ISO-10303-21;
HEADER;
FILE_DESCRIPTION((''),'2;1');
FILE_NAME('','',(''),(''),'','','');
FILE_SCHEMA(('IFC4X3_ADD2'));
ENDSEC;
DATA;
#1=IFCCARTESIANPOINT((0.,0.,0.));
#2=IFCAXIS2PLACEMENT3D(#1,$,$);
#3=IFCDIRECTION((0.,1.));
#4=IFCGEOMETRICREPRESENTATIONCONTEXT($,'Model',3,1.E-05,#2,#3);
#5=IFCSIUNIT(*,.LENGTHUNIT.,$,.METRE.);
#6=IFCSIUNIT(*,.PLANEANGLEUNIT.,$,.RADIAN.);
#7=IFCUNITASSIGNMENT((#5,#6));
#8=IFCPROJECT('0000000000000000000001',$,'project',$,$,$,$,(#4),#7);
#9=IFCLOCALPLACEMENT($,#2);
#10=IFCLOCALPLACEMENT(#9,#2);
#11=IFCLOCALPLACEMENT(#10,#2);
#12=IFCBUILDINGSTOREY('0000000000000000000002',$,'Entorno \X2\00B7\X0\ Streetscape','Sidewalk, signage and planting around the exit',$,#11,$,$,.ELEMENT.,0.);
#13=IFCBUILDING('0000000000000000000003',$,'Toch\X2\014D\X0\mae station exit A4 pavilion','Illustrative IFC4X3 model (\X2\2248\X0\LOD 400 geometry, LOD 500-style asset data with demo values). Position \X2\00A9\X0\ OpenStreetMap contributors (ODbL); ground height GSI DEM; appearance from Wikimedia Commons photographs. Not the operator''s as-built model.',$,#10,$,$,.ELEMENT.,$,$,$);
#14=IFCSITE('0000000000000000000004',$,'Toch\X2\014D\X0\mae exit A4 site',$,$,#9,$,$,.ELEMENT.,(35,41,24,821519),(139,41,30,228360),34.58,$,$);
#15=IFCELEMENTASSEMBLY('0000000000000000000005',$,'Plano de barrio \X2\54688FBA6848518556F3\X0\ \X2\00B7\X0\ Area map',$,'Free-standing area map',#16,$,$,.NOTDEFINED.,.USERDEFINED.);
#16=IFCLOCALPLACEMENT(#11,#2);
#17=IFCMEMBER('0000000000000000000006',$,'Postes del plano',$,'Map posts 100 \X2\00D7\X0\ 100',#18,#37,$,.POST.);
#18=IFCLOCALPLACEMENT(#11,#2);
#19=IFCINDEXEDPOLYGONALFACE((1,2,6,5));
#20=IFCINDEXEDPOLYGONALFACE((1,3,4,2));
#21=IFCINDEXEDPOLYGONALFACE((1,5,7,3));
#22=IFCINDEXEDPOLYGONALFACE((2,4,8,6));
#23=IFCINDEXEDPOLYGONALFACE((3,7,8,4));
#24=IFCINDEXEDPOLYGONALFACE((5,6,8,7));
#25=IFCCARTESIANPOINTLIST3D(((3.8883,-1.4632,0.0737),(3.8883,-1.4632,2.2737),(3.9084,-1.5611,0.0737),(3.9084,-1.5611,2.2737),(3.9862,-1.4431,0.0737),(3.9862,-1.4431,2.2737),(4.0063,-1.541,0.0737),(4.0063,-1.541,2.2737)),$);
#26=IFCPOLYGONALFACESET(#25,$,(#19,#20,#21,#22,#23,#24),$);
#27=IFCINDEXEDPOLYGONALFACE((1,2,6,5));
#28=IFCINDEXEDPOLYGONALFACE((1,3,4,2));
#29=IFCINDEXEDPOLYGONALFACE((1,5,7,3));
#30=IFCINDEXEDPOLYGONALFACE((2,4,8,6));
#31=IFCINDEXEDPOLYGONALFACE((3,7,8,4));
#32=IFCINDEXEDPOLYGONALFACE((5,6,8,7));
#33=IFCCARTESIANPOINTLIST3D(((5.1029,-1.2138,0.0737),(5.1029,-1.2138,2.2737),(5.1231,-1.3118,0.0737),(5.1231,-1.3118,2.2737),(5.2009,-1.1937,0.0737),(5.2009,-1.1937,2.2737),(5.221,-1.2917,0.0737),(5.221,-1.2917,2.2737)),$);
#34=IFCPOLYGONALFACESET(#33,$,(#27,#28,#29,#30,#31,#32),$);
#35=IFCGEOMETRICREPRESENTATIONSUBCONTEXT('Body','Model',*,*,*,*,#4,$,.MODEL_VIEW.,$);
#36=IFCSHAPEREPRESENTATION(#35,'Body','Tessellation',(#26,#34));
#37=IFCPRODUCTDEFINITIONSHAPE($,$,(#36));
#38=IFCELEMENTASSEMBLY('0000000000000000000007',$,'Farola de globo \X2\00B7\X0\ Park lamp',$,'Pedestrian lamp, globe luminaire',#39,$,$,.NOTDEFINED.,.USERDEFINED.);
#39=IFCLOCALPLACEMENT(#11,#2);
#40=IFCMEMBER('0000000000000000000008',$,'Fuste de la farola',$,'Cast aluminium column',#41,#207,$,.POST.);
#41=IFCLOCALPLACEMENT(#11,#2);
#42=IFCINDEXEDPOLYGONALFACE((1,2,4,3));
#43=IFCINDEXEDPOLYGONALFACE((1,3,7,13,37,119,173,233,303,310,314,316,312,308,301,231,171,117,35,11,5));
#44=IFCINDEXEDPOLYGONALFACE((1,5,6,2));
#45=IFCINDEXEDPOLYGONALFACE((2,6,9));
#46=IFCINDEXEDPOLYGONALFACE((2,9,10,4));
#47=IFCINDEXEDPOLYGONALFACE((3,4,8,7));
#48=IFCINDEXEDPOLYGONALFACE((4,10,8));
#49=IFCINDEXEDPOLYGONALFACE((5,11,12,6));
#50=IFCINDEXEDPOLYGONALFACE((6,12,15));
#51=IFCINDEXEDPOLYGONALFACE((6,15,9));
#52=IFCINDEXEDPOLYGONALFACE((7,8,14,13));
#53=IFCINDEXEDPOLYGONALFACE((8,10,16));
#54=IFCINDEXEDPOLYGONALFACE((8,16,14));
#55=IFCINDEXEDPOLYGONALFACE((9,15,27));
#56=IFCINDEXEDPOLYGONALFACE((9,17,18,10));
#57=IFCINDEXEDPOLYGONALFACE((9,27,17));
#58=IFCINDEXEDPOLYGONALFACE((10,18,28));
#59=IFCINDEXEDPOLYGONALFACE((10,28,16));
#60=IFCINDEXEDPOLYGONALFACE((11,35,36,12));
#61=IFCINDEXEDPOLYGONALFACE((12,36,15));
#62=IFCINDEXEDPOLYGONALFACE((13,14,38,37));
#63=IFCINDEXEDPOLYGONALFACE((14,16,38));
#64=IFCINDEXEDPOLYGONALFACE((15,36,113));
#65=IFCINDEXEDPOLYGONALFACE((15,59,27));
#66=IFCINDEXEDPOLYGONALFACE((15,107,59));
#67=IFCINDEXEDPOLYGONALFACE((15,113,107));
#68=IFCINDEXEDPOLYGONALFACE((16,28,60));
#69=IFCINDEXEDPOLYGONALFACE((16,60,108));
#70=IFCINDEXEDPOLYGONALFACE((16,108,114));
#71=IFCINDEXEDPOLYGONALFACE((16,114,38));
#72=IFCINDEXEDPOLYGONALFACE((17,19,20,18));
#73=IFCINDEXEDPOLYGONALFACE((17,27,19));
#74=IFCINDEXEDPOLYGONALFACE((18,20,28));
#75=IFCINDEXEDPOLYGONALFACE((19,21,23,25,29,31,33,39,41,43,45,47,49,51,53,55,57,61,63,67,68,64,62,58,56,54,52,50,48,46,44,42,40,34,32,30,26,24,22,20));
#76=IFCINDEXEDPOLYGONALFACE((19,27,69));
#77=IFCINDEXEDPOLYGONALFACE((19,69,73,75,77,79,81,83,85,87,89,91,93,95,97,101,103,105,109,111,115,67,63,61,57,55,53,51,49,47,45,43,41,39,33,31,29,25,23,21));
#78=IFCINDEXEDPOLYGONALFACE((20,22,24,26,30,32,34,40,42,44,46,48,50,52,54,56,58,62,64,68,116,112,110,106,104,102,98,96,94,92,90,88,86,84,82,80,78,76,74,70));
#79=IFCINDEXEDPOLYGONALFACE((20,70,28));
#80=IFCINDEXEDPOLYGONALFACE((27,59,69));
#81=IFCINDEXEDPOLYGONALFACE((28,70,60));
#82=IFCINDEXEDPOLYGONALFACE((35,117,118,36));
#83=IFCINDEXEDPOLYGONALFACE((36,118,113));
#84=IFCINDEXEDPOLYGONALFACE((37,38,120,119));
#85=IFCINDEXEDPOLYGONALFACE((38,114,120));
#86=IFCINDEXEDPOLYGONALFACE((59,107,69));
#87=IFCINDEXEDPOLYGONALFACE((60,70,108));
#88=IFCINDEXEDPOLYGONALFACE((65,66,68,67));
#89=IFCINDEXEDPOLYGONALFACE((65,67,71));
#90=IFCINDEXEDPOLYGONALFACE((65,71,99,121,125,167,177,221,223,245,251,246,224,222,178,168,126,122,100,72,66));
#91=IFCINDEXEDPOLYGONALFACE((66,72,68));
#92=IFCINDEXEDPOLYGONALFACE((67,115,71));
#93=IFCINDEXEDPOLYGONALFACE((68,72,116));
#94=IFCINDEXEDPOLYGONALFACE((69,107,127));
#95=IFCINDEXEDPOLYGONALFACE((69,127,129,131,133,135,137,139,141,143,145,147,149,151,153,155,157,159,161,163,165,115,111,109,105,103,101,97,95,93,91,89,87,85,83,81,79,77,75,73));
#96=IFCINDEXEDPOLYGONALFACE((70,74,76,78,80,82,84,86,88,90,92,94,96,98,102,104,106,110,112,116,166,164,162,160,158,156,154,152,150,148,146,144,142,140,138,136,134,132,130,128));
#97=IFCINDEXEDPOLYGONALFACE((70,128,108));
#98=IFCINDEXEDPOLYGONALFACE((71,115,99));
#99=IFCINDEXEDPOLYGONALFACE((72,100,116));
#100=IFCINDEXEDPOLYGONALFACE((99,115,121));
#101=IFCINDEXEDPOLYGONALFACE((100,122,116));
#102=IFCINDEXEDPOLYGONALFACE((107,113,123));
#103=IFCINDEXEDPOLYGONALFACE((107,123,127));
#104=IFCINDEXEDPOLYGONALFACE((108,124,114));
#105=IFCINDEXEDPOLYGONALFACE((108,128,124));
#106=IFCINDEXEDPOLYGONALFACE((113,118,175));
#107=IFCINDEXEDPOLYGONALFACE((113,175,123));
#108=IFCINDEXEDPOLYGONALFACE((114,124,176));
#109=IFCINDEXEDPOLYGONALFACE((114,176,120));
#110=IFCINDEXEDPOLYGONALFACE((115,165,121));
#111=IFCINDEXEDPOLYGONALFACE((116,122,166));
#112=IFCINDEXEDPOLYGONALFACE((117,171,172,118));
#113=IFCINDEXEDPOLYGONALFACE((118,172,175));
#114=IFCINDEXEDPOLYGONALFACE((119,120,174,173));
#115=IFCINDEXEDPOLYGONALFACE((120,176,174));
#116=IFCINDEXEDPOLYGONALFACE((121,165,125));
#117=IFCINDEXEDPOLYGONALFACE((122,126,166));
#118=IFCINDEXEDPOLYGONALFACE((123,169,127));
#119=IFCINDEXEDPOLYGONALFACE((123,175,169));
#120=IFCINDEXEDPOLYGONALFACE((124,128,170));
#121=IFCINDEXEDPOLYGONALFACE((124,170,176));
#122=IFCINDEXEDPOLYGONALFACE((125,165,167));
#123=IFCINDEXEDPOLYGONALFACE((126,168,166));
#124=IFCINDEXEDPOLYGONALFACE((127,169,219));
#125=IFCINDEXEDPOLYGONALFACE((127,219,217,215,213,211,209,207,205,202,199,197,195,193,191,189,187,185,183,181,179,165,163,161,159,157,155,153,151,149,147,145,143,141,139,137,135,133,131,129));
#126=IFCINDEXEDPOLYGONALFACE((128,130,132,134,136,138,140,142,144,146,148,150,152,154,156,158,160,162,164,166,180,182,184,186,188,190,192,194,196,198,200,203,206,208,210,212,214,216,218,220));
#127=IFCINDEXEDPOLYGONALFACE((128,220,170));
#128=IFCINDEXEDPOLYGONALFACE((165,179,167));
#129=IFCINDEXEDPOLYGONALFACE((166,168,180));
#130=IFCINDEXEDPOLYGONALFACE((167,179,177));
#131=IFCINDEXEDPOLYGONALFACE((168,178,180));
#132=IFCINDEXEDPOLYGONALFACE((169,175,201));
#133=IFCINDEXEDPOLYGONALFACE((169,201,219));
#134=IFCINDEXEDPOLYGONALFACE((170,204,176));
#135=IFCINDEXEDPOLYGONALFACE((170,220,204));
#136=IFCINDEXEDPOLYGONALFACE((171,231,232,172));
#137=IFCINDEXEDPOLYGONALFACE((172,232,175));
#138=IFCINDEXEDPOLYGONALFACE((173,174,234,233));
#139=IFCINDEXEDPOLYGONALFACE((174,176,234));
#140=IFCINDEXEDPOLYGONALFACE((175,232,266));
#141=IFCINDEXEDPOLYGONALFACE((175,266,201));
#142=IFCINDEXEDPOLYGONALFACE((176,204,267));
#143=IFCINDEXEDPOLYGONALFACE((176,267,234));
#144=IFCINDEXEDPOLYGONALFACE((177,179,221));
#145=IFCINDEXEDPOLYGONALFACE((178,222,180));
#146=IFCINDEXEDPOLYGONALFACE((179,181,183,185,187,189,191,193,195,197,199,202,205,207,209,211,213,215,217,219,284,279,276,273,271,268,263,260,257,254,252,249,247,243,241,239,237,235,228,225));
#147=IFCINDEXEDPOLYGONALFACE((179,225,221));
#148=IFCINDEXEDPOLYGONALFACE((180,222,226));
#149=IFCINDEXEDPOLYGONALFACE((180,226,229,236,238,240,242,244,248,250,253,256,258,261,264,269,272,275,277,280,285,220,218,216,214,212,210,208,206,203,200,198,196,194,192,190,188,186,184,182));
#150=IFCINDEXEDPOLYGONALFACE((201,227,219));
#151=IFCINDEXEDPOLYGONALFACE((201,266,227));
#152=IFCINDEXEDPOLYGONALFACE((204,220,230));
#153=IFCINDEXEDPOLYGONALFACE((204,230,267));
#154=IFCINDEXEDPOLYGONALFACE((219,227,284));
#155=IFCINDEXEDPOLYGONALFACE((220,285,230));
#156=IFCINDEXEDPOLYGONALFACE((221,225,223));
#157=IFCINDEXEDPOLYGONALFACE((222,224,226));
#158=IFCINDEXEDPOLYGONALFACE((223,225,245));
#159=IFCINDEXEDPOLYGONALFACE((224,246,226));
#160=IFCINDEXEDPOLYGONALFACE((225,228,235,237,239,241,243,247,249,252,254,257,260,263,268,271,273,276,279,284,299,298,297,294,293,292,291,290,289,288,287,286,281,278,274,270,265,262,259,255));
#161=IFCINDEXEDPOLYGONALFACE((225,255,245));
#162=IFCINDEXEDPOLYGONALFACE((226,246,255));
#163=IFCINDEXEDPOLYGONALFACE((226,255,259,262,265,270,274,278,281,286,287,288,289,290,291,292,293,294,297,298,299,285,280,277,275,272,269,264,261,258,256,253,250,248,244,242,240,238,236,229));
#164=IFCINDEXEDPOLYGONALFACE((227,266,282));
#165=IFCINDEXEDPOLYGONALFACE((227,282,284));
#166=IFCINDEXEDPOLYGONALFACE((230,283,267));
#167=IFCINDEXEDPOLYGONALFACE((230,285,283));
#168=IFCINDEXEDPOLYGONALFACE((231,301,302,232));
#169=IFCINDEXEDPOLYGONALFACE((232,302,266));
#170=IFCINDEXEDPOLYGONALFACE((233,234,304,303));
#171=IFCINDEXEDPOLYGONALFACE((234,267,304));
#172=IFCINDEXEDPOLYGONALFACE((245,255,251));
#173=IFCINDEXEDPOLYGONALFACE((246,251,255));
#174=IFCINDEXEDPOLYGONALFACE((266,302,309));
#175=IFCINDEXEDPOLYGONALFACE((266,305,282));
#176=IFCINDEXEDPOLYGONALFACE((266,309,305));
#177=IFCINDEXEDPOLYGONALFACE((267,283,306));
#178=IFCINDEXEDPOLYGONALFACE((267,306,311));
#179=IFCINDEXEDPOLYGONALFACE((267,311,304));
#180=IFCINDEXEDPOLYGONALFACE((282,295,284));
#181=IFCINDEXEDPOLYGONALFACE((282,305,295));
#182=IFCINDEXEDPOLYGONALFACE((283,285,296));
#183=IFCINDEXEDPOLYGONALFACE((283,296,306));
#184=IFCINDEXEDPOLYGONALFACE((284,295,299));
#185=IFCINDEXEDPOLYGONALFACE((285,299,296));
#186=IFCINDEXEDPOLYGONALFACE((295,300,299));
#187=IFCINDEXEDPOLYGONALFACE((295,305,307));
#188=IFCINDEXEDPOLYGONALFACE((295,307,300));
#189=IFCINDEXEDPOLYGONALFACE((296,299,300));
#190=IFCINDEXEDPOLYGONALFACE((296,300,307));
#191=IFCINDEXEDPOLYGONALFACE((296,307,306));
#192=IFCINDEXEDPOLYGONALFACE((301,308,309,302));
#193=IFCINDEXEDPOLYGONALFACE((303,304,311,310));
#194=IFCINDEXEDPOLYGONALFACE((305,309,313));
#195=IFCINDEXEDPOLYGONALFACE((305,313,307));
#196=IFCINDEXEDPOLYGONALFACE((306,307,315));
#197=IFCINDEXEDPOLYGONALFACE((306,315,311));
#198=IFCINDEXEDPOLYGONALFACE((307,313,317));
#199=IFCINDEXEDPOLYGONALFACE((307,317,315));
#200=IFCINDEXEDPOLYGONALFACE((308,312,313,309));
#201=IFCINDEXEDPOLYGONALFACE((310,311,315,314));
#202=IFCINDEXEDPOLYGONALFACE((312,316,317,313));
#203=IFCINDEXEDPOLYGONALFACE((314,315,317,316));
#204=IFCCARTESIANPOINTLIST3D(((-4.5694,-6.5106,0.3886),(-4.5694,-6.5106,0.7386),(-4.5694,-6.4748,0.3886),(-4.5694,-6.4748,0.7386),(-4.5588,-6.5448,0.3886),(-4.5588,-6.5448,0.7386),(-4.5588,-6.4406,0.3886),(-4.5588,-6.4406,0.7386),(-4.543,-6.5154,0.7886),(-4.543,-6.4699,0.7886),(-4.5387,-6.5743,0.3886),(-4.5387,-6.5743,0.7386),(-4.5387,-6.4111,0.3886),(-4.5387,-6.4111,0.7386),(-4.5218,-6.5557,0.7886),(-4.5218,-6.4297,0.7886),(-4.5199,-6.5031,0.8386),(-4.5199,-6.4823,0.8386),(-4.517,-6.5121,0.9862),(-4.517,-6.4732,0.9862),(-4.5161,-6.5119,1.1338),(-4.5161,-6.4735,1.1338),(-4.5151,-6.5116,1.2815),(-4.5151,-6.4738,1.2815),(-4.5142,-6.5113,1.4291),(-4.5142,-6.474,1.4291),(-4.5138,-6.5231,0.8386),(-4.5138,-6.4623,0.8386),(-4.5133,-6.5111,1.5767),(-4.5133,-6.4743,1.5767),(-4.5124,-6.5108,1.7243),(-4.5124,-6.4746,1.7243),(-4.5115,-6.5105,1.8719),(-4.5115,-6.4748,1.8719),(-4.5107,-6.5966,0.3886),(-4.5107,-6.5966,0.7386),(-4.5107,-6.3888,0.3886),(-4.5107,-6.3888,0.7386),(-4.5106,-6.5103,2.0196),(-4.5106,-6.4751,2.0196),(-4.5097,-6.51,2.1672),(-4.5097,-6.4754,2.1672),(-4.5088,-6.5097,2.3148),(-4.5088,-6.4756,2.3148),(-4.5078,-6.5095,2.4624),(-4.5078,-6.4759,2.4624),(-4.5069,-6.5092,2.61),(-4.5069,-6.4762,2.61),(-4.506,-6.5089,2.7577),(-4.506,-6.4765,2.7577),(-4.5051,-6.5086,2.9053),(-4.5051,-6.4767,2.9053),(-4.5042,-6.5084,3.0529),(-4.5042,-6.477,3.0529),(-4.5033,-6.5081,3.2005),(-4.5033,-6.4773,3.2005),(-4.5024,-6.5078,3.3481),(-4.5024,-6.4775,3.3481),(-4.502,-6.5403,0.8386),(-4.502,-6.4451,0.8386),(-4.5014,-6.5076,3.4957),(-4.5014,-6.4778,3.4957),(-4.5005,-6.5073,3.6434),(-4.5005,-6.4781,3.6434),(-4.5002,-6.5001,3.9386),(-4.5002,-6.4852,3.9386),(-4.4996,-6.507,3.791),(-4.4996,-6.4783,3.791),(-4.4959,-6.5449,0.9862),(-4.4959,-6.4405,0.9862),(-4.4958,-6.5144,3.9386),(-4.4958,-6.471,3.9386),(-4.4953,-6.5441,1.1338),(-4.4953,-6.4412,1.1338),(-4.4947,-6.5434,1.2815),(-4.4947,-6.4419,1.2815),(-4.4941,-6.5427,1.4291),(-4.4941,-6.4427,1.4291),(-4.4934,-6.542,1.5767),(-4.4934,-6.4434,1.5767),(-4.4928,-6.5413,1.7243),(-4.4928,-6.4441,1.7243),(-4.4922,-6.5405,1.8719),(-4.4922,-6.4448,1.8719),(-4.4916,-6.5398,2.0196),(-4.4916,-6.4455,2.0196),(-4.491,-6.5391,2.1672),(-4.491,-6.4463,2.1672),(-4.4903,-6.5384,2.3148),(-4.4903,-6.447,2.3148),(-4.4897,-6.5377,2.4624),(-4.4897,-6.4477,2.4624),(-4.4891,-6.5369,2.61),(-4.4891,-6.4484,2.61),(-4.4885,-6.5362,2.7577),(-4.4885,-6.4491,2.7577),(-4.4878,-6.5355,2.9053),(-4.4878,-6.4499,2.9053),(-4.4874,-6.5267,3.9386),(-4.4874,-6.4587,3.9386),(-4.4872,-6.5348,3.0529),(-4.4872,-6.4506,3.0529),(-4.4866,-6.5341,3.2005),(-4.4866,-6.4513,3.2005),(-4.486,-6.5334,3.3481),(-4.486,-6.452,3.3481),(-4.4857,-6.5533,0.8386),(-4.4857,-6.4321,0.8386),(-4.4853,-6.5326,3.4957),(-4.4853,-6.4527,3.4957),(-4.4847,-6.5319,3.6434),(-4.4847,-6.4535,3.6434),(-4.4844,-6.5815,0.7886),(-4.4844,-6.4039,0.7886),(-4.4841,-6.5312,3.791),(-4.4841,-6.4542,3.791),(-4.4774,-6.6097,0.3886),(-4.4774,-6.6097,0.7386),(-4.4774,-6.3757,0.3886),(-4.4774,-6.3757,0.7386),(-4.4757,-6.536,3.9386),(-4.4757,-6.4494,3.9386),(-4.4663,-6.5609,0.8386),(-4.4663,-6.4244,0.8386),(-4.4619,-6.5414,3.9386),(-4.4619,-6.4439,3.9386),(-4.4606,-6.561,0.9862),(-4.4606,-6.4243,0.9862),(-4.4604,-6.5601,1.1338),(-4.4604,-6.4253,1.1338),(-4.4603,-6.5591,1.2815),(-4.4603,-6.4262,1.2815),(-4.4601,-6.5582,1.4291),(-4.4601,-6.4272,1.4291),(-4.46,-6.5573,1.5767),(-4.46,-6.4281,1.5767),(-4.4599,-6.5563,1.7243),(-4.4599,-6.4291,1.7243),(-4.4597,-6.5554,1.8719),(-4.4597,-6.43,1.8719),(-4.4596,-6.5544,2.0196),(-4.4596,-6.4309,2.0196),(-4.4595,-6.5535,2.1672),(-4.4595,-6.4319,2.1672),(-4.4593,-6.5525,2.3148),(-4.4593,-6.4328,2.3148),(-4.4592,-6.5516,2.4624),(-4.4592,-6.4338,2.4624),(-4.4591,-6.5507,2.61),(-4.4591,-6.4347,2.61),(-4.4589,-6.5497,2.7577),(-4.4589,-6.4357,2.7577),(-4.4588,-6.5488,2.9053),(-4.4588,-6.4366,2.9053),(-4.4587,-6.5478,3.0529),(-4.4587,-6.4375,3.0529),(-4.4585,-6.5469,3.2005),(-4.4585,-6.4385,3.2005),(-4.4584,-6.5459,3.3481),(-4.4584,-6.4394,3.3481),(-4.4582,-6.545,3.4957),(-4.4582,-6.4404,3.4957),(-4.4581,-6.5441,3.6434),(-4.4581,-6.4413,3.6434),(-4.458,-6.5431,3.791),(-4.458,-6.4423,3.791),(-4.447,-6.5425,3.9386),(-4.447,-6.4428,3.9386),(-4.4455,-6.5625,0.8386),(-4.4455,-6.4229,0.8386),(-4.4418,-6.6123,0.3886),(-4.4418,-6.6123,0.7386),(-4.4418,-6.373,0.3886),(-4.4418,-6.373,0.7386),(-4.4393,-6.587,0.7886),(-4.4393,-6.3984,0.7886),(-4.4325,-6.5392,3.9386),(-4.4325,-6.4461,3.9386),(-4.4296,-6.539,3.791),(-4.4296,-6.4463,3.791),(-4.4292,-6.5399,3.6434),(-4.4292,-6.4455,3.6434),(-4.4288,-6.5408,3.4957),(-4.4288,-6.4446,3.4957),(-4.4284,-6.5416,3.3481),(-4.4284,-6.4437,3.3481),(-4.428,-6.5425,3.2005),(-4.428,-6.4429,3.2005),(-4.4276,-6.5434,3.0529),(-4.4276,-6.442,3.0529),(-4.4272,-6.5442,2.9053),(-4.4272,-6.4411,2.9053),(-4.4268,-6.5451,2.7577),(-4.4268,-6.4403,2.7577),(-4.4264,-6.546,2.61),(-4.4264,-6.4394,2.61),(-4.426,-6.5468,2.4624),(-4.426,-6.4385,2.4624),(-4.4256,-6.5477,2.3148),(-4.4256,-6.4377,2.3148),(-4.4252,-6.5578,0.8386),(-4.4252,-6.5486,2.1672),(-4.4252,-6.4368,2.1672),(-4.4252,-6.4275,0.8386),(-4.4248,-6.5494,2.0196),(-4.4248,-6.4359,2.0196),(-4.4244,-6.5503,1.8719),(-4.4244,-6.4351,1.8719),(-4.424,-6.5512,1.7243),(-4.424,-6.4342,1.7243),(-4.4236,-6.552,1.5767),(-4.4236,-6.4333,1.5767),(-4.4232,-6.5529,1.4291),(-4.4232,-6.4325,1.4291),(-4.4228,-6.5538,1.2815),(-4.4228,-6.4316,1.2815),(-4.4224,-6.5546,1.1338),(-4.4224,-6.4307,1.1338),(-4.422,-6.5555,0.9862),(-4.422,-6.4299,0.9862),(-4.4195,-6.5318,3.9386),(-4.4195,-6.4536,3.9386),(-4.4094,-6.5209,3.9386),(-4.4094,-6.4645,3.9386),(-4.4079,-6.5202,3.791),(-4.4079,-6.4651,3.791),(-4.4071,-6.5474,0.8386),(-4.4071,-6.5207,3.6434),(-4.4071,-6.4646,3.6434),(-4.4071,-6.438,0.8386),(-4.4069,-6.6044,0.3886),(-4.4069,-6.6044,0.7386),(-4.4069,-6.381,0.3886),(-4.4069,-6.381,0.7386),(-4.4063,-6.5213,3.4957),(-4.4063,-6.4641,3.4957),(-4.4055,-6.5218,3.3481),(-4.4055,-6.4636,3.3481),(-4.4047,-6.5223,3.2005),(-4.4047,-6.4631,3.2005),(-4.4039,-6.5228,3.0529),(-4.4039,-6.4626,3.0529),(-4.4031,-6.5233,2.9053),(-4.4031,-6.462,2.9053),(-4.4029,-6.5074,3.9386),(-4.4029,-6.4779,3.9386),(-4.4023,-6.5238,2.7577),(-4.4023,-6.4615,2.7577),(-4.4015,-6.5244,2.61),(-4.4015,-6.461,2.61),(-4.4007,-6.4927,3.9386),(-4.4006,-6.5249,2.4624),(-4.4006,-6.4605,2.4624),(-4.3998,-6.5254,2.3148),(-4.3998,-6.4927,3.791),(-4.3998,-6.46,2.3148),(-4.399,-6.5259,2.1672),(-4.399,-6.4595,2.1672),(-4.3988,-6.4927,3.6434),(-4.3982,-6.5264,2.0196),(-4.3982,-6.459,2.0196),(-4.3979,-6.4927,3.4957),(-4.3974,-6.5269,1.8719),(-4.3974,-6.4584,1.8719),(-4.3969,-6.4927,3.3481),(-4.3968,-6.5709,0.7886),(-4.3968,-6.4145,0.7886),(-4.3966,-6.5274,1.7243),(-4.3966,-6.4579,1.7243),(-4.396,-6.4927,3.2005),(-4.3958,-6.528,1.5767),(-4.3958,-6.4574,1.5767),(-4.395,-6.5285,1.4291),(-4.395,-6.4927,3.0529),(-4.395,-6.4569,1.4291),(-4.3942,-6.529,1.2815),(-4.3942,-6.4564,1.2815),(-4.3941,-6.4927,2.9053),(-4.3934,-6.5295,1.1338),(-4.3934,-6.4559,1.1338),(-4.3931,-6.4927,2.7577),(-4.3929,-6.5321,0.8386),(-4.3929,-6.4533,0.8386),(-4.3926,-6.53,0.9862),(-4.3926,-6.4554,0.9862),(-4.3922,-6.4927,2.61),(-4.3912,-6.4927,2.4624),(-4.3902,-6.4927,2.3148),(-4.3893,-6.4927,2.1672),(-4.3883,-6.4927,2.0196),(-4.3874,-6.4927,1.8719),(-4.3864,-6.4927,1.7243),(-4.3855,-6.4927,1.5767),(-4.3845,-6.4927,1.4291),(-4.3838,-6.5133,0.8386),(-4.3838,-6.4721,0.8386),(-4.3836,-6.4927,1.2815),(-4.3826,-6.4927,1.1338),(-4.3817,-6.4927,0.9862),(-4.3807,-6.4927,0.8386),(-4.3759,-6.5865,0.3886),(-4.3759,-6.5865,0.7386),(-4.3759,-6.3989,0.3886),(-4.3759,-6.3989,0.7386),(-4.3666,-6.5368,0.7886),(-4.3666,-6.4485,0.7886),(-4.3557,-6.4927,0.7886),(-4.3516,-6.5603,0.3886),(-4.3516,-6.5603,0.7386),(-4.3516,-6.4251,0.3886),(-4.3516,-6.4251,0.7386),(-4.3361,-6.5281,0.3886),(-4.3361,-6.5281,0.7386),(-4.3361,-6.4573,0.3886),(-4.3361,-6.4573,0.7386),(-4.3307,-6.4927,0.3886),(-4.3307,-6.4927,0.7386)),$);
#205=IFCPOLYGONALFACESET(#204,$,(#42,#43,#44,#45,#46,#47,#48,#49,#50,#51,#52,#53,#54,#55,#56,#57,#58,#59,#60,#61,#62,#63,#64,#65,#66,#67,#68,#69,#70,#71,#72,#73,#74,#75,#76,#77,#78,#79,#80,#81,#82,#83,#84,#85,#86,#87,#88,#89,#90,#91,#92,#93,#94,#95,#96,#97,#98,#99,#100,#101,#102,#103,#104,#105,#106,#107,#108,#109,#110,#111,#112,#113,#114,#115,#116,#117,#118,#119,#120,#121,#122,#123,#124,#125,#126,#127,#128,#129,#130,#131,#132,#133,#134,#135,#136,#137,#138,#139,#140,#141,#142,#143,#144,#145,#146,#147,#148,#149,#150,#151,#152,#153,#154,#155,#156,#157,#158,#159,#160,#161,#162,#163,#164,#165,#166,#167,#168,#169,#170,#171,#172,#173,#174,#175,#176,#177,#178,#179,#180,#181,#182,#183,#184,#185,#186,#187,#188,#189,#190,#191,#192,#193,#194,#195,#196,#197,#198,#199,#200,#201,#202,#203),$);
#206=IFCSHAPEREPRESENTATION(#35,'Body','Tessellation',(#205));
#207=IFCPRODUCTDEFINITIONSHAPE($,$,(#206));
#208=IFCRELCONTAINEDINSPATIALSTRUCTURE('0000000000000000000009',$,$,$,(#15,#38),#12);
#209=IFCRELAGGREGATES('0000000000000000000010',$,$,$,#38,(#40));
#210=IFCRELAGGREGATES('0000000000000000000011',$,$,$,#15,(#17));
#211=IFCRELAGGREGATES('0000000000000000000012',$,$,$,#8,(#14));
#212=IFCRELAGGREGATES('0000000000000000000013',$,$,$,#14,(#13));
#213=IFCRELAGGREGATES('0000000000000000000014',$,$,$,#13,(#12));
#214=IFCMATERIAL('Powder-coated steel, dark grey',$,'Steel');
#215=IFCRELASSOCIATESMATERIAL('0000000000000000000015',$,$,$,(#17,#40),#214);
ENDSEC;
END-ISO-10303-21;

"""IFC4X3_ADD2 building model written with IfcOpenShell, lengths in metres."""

from ifc_helpers import new_model, entity, si_unit, direction, frame, frame_2d, origin, place, context, subcontext, project, spatial, rectangle, extrude, material, element, aggregate, save


model = new_model("IFC4X3_ADD2")

# Units and contexts
model_context = context("Model", 3, precision=1e-05, world=origin(), true_north=direction((0.0, 1.0)))
body_context = subcontext(model_context, "Body", "Model", "MODEL_VIEW")
ifc_project = project(units=[si_unit("LENGTHUNIT", "METRE"), si_unit("PLANEANGLEUNIT", "RADIAN")], contexts=[model_context])

# Site, building, storey
site_placement = place(None, origin())
site = spatial("IfcSite", under=ifc_project, at=site_placement, Name="Tochōmae exit A4 site", CompositionType="ELEMENT", RefLatitude=(35, 41, 24, 821519), RefLongitude=(139, 41, 30, 228360), RefElevation=34.58)
building_placement = place(site_placement, origin())
building = spatial("IfcBuilding", under=site, at=building_placement, Name="Tochōmae station exit A4 pavilion", Description="Illustrative IFC4X3 model (≈LOD 400 geometry, LOD 500-style asset data with demo values). Position © OpenStreetMap contributors (ODbL); ground height GSI DEM; appearance from Wikimedia Commons photographs. Not the operator's as-built model.", CompositionType="ELEMENT")
storey_placement = place(building_placement, origin())
storey = spatial("IfcBuildingStorey", under=building, at=storey_placement, Name="Entorno · Streetscape", Description="Sidewalk, signage and planting around the exit", CompositionType="ELEMENT", Elevation=0.0)

# Element assemblies, members
assembly_1_placement = place(building_placement, origin())
assembly_1 = element("IfcElementAssembly", 1, at=assembly_1_placement, inside=storey, Name="Plano de barrio 周辺案内図 · Area map", ObjectType="Free-standing area map", AssemblyPlace="NOTDEFINED", PredefinedType="USERDEFINED")
ifc_material_1 = material(Name="Powder-coated steel, dark grey", Category="Steel")
member_1_placement = place(building_placement, origin())
member_1 = element("IfcMember", 2, at=member_1_placement, material=ifc_material_1, Name="Postes del plano", ObjectType="Map posts 100 × 100", PredefinedType="POST", context=body_context, shape_type="SweptSolid", body=[
    extrude(rectangle(XDim=0.1, YDim=0.1, at=frame_2d((0.0, 0.0), x_axis=(0.979575, 0.201078))), frame((3.9473, -1.5021, 0.0737)), (0.0, 0.0, 1.0), 2.2),
    extrude(rectangle(XDim=0.1, YDim=0.1, at=frame_2d((0.0, 0.0), x_axis=(0.979575, 0.201078))), frame((5.162, -1.2528, 0.0737)), (0.0, 0.0, 1.0), 2.2),
])
assembly_2_placement = place(building_placement, origin())
assembly_2 = element("IfcElementAssembly", 3, at=assembly_2_placement, inside=storey, Name="Farola de globo · Park lamp", ObjectType="Pedestrian lamp, globe luminaire", AssemblyPlace="NOTDEFINED", PredefinedType="USERDEFINED")
member_2_placement = place(building_placement, origin())
member_2 = element("IfcMember", 4, at=member_2_placement, material=ifc_material_1, Name="Fuste de la farola", ObjectType="Cast aluminium column", PredefinedType="POST", context=body_context, shape_type="SweptSolid", body=[
    entity("IfcRevolvedAreaSolid", entity("IfcArbitraryClosedProfileDef", "AREA", None, entity("IfcPolyline", [entity("IfcCartesianPoint", [0.0, 0.0]), entity("IfcCartesianPoint", [0.12, 0.0]), entity("IfcCartesianPoint", [0.12, 0.35]), entity("IfcCartesianPoint", [0.07, 0.45]), entity("IfcCartesianPoint", [0.05, 3.55]), entity("IfcCartesianPoint", [0.0, 3.55]), entity("IfcCartesianPoint", [0.0, 0.0])])), entity("IfcAxis2Placement3D", entity("IfcCartesianPoint", [-4.4507, -6.4927, 0.3886]), entity("IfcDirection", [0.0, -1.0, 0.0]), entity("IfcDirection", [1.0, 0.0, 0.0])), entity("IfcAxis1Placement", entity("IfcCartesianPoint", [0.0, 0.0, 0.0]), entity("IfcDirection", [0.0, 1.0, 0.0])), 6.283185),
])

aggregate(assembly_2, [member_2])

aggregate(assembly_1, [member_1])

save(model, "model.ifc")
